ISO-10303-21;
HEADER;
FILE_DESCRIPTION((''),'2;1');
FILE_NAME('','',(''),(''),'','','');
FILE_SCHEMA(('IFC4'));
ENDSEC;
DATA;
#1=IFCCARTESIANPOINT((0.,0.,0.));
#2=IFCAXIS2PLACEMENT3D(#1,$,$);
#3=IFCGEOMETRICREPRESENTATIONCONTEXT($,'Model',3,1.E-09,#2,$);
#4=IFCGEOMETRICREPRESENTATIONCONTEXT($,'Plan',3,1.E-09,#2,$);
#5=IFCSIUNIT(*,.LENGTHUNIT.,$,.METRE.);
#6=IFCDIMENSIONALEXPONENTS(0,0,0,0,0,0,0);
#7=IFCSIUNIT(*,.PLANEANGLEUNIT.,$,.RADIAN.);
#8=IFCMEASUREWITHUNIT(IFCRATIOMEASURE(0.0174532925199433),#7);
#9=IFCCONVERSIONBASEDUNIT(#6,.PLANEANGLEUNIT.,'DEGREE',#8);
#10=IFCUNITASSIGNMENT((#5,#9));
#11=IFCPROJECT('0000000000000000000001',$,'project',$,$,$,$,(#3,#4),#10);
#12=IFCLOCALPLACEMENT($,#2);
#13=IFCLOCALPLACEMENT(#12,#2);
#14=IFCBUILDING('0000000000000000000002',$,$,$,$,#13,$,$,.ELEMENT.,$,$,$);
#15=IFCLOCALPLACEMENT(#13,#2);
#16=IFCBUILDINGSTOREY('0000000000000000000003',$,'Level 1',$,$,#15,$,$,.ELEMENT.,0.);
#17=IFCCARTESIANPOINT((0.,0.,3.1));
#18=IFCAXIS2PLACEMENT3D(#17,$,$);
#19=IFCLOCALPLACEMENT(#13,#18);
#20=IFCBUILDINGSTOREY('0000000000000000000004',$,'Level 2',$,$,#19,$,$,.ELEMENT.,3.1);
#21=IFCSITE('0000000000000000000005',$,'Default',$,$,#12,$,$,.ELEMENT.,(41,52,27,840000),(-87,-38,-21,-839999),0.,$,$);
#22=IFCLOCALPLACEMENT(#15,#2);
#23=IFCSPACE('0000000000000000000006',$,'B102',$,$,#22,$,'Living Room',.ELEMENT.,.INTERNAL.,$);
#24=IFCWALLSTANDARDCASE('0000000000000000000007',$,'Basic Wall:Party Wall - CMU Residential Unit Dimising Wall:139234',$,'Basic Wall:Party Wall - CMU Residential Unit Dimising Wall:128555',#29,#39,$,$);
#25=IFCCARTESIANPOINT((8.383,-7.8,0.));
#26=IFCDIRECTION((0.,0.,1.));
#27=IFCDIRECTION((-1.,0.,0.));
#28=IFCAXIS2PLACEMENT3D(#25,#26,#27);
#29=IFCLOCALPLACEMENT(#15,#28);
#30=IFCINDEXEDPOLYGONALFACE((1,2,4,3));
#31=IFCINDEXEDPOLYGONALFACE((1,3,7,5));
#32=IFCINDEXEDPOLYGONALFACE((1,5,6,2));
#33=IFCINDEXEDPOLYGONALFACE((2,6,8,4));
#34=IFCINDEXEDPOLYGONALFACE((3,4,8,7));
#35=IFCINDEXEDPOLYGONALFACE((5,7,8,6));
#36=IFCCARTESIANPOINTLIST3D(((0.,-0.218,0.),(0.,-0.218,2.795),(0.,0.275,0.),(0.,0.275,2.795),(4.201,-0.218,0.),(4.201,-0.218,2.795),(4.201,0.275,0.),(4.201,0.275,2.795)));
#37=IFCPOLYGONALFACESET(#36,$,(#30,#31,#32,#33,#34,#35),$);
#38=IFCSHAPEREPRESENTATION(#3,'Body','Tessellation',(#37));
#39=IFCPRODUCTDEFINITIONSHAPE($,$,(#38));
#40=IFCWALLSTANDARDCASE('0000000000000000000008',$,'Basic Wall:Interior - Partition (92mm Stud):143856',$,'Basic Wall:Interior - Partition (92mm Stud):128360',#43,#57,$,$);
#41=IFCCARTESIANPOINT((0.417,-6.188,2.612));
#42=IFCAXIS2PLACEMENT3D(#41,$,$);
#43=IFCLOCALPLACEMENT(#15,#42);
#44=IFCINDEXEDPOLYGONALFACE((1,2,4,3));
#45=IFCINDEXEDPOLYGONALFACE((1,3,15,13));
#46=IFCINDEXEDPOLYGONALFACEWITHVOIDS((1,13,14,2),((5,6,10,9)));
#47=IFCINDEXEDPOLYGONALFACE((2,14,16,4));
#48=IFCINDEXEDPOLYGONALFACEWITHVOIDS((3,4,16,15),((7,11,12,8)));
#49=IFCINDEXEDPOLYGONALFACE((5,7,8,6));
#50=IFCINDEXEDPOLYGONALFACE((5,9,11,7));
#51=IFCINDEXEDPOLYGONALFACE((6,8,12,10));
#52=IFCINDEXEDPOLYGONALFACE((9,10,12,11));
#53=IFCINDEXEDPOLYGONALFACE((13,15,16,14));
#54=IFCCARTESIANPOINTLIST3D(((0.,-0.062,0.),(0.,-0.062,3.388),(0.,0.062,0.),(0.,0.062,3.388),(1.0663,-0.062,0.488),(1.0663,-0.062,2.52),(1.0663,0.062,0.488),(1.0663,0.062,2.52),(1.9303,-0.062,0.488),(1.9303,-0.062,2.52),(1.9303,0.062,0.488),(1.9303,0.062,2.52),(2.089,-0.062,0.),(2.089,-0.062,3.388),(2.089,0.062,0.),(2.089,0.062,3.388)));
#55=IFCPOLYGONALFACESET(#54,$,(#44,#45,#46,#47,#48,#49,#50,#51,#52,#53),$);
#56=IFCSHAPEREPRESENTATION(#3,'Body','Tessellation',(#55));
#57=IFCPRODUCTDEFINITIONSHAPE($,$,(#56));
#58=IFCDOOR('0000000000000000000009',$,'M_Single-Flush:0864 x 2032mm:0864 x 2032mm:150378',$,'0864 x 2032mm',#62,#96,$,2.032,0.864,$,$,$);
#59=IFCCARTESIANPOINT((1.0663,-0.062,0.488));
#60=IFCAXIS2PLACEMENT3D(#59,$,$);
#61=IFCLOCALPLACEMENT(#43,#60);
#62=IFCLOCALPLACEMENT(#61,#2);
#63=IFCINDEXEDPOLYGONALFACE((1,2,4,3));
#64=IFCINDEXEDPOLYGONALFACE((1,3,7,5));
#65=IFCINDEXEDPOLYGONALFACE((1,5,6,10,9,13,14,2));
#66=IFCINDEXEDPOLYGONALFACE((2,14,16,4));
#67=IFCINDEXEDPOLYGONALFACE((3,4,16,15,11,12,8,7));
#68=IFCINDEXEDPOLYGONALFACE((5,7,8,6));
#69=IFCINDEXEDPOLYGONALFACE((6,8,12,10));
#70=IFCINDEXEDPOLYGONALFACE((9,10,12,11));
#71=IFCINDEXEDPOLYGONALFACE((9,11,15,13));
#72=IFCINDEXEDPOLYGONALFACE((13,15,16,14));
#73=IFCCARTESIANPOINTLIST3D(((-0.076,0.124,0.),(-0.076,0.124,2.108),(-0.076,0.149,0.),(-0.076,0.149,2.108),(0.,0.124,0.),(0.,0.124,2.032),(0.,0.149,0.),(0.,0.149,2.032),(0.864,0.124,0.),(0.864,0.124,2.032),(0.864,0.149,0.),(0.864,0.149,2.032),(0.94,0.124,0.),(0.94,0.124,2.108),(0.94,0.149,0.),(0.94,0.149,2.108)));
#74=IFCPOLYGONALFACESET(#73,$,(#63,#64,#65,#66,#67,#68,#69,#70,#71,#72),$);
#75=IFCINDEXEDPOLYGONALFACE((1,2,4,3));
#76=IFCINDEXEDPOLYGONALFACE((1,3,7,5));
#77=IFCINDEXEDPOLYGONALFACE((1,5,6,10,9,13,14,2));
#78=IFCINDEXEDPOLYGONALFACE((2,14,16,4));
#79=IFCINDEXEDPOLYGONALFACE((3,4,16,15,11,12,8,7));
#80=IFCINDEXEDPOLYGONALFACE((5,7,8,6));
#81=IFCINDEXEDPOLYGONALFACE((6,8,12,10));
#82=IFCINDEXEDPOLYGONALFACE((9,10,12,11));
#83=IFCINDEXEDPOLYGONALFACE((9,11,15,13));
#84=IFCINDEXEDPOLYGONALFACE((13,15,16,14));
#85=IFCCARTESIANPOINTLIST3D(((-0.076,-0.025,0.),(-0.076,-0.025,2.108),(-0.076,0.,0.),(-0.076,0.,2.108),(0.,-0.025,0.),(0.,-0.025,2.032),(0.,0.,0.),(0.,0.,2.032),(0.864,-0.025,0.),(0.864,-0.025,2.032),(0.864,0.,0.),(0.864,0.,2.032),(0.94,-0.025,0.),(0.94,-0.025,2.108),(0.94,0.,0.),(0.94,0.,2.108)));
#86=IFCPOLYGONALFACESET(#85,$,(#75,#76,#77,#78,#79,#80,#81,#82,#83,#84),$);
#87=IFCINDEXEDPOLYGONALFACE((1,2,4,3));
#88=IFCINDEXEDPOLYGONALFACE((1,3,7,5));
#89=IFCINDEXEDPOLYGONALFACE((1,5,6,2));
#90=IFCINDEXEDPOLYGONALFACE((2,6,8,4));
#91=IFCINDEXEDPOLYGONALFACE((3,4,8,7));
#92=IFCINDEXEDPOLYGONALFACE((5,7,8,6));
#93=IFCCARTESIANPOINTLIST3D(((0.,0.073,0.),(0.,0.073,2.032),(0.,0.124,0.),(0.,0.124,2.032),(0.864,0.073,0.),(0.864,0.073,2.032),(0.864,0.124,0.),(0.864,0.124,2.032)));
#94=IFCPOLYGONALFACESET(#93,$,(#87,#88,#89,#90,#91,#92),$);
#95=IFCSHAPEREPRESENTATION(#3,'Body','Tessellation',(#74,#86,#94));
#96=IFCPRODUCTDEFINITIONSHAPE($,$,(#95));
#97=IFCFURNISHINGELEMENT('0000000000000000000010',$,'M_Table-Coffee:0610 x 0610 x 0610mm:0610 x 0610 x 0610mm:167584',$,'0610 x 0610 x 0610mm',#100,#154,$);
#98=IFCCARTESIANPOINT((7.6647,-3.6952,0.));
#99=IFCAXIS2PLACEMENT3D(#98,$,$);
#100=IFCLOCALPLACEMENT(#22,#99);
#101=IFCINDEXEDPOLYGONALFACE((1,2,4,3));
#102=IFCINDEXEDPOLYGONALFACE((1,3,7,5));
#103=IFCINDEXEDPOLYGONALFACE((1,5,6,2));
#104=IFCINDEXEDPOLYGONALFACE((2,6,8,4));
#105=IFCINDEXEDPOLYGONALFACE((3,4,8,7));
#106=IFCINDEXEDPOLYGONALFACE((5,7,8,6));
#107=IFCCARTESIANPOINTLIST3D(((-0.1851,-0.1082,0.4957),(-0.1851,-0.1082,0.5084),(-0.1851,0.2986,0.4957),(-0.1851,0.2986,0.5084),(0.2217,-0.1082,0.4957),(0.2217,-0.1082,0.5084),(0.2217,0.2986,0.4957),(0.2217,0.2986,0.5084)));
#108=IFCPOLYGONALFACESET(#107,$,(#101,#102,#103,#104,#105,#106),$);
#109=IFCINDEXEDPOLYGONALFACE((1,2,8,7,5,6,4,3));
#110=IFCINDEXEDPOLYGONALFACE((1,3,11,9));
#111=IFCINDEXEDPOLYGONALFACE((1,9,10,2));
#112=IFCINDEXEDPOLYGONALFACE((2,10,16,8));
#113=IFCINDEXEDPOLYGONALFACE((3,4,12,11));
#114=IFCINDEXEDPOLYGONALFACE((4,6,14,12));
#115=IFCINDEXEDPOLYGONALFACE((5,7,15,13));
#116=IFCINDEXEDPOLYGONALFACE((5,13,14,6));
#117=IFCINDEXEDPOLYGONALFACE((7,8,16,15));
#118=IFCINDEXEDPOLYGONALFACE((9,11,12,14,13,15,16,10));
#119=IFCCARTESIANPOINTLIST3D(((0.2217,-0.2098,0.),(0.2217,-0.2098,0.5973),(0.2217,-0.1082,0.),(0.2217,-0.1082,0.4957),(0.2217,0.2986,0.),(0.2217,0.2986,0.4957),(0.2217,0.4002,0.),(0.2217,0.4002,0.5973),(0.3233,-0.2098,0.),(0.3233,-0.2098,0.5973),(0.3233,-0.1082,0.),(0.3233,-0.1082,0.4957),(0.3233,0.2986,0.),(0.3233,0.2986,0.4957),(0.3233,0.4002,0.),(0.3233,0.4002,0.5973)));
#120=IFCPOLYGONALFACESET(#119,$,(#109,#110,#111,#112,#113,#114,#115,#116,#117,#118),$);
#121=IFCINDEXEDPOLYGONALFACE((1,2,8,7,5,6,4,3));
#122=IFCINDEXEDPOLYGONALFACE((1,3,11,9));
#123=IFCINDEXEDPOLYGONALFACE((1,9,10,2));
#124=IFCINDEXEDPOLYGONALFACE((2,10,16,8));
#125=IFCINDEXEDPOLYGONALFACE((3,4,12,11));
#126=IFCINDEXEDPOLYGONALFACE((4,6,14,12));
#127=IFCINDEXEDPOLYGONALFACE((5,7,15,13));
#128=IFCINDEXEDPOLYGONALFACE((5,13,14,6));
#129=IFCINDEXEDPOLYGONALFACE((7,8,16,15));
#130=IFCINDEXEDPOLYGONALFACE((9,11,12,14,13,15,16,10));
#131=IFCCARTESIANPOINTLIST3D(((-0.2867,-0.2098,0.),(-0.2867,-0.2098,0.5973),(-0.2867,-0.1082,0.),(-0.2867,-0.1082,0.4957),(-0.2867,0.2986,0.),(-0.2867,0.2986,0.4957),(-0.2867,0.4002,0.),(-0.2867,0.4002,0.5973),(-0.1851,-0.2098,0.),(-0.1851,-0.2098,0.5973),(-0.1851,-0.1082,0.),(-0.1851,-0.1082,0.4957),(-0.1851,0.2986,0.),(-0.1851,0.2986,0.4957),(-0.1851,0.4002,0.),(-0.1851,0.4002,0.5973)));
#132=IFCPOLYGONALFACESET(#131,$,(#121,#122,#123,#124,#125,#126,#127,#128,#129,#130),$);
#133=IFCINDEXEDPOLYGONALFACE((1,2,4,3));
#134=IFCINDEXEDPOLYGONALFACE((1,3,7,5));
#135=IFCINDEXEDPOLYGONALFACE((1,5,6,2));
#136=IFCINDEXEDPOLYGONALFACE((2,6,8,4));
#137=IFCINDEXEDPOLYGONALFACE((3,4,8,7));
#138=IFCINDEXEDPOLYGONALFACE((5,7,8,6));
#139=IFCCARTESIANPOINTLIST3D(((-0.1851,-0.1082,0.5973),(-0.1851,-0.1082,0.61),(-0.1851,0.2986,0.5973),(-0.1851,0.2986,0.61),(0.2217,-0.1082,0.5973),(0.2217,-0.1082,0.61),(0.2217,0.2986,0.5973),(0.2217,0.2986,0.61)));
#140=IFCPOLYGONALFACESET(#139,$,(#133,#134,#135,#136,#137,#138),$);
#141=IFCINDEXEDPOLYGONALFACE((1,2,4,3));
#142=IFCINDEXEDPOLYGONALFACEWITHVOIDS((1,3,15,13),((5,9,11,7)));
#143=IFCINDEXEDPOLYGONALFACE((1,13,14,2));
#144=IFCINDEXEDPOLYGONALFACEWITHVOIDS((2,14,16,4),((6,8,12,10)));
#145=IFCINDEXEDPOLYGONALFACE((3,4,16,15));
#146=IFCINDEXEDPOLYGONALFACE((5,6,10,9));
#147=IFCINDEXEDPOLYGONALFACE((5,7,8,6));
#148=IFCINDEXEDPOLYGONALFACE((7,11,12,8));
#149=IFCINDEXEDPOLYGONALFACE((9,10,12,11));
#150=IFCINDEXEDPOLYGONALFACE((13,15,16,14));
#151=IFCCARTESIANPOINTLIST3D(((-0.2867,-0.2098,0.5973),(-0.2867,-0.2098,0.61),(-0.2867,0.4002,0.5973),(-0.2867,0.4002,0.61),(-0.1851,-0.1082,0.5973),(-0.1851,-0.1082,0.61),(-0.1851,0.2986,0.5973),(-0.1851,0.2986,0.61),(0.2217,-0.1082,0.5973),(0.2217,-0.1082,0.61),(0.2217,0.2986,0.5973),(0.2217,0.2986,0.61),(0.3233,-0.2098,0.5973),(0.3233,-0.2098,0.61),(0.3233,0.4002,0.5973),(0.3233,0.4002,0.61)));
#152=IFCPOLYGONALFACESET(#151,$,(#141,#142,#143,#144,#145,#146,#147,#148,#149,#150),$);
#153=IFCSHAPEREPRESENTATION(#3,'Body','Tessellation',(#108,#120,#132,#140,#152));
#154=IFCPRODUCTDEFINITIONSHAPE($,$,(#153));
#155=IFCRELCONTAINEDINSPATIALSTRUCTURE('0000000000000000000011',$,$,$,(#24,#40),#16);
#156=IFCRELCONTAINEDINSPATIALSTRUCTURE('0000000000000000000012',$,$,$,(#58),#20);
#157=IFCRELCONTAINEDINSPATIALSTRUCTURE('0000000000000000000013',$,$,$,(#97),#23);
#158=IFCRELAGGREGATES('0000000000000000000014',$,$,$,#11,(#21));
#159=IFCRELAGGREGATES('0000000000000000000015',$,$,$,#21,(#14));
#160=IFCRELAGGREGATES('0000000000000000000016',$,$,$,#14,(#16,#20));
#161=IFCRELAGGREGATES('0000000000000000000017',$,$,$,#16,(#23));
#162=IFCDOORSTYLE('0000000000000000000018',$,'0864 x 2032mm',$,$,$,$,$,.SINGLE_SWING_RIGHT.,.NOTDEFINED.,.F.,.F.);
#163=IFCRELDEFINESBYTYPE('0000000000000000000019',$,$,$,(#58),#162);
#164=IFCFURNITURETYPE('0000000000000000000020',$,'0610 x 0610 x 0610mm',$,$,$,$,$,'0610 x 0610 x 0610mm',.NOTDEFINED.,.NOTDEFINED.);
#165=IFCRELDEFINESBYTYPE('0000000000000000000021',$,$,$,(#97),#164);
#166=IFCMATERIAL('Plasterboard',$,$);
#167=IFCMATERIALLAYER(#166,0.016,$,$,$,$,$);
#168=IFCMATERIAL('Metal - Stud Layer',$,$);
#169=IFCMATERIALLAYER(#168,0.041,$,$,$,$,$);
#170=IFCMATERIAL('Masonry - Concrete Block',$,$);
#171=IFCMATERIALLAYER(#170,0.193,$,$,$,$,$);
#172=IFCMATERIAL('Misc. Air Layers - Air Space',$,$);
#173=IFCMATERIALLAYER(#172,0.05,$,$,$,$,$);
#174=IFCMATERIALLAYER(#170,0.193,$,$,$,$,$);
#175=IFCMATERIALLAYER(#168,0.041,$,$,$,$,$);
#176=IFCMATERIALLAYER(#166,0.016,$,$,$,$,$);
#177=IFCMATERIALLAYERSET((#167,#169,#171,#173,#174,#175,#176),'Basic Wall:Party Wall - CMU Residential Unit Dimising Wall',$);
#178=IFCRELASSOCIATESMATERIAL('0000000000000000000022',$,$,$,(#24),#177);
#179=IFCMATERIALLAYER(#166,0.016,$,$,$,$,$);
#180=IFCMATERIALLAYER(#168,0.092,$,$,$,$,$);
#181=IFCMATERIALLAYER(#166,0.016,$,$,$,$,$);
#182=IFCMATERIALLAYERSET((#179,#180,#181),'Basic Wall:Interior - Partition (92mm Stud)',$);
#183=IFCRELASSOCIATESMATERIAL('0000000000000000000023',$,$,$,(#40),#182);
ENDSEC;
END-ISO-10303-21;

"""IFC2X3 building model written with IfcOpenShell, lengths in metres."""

from ifc_helpers import new_model, entity, si_unit, converted_unit, frame, frame_2d, origin, origin_2d_with_axis, place, context, project, spatial, polyline, rectangle, outline, extrude, clip, bounded_halfspace, source, transform, mapped, material, layer, layer_set, layer_usage, type_object, type_shapes, element, fill, save


model = new_model("IFC2X3")

# Units and contexts
model_context = context("Model", 3, precision=1e-09, world=origin())
plan_context = context("Plan", 3, precision=1e-09, world=origin())
ifc_project = project(units=[si_unit("LENGTHUNIT", "METRE"), converted_unit("PLANEANGLEUNIT", "DEGREE", entity("IfcRatioMeasure", 0.0174532925199433), si_unit("PLANEANGLEUNIT", "RADIAN"), dimensions=[0, 0, 0, 0, 0, 0, 0])], contexts=[model_context, plan_context])

# Site, building, storey
site_placement = place(None, origin())
site = spatial("IfcSite", under=ifc_project, at=site_placement, Name="Default", CompositionType="ELEMENT", RefLatitude=(41, 52, 27, 840000), RefLongitude=(-87, -38, -21, -839999), RefElevation=0.0)
building_placement = place(site_placement, origin())
building = spatial("IfcBuilding", under=site, at=building_placement, CompositionType="ELEMENT")
storey_1_placement = place(building_placement, origin())
storey_1 = spatial("IfcBuildingStorey", under=building, at=storey_1_placement, Name="Level 1", CompositionType="ELEMENT", Elevation=0.0)

# Shared definitions
ifc_material_1 = material(Name="Misc. Air Layers - Air Space")
ifc_material_2 = material(Name="Masonry - Concrete Block")
ifc_material_3 = material(Name="Metal - Stud Layer")
ifc_material_4 = material(Name="Plasterboard")

# Wall
ifc_layer_1 = layer(ifc_material_4, 0.016)
ifc_layer_2 = layer(ifc_material_3, 0.041)
ifc_layer_3 = layer(ifc_material_2, 0.193)
ifc_layer_4 = layer(ifc_material_1, 0.05)
ifc_layer_5 = layer(ifc_material_2, 0.193)
ifc_layer_6 = layer(ifc_material_3, 0.041)
ifc_layer_7 = layer(ifc_material_4, 0.016)
ifc_layer_set_1 = layer_set([ifc_layer_1, ifc_layer_2, ifc_layer_3, ifc_layer_4, ifc_layer_5, ifc_layer_6, ifc_layer_7], Name="Basic Wall:Party Wall - CMU Residential Unit Dimising Wall")
ifc_layer_usage_1 = layer_usage(ifc_layer_set_1, "AXIS2", "NEGATIVE", 0.275)
wall_1_placement = place(storey_1_placement, frame((8.383, -7.8, 0.0), z_axis=(0.0, 0.0, 1.0), x_axis=(-1.0, 0.0, 0.0)))
element("IfcWallStandardCase", 1, at=wall_1_placement, inside=storey_1, material=ifc_layer_usage_1, Name="Basic Wall:Party Wall - CMU Residential Unit Dimising Wall:139234", ObjectType="Basic Wall:Party Wall - CMU Residential Unit Dimising Wall:128555", context=model_context, shape_type="Clipping", body=[
    clip(clip(extrude(rectangle(XDim=4.201, YDim=0.55, at=frame_2d((2.1005, 0.0), x_axis=(-1.0, 0.0))), origin(), (0.0, 0.0, 1.0), 2.795), bounded_halfspace(frame((0.0, -0.218, 2.795), z_axis=(0.0, 1.0, 0.0), x_axis=(-1.0, 0.0, 0.0)), True, frame((0.0, -0.218, 2.795), z_axis=(0.0, 1.0, 0.0), x_axis=(-1.0, 0.0, 0.0)), polyline([(0.0, 0.0), (-3.708, 0.0), (-4.201, 0.0), (-4.201, -2.795), (0.0, -2.795), (0.0, 0.0)]))), bounded_halfspace(frame((4.201, 0.275, 0.0), z_axis=(-1.0, 0.0, 0.0), x_axis=(0.0, -1.0, 0.0)), True, frame((4.201, 0.275, 0.0), z_axis=(-1.0, 0.0, 0.0), x_axis=(0.0, -1.0, 0.0)), polyline([(0.0, 0.0), (0.493, 0.0), (0.493, 2.795), (0.0, 2.795), (0.0, 0.0)]))),
])

# Wall, opening
ifc_layer_8 = layer(ifc_material_4, 0.016)
ifc_layer_9 = layer(ifc_material_3, 0.092)
ifc_layer_10 = layer(ifc_material_4, 0.016)
ifc_layer_set_2 = layer_set([ifc_layer_8, ifc_layer_9, ifc_layer_10], Name="Basic Wall:Interior - Partition (92mm Stud)")
ifc_layer_usage_2 = layer_usage(ifc_layer_set_2, "AXIS2", "NEGATIVE", 0.062)
wall_2_placement = place(storey_1_placement, frame((0.417, -6.188, 2.612)))
wall_2 = element("IfcWallStandardCase", 2, at=wall_2_placement, inside=storey_1, material=ifc_layer_usage_2, Name="Basic Wall:Interior - Partition (92mm Stud):143856", ObjectType="Basic Wall:Interior - Partition (92mm Stud):128360", context=model_context, shape_type="SweptSolid", body=[
    extrude(rectangle(XDim=2.089, YDim=0.124, at=frame_2d((1.0445, 0.0), x_axis=(-1.0, 0.0))), origin(), (0.0, 0.0, 1.0), 3.388),
])
opening_1_placement = place(wall_2_placement, frame((1.0663, -0.062, 0.488)))
opening_1 = element("IfcOpeningElement", 3, at=opening_1_placement, cuts=wall_2, ObjectType="Opening", context=model_context, shape_type="SweptSolid", body=[
    extrude(rectangle(XDim=0.864, YDim=2.032, at=frame_2d((1.016, 0.432), x_axis=(0.0, 1.0))), frame((0.0, 0.0, 0.0), z_axis=(0.0, 1.0, 0.0), x_axis=(0.0, 0.0, 1.0)), (0.0, 0.0, 1.0), 0.124),
])

# Shared definitions
storey_2_placement = place(building_placement, frame((0.0, 0.0, 3.1)))
storey_2 = spatial("IfcBuildingStorey", under=building, at=storey_2_placement, Name="Level 2", CompositionType="ELEMENT", Elevation=3.1)

# Door
door_style_1 = type_object("IfcDoorStyle", Name="0864 x 2032mm", ConstructionType="NOTDEFINED", OperationType="SINGLE_SWING_RIGHT", ParameterTakesPrecedence=False, Sizeable=False)
shared_shape_1 = source(origin(), model_context, "Body", "SweptSolid", [
    extrude(outline(polyline([(-0.508, -1.073), (0.508, -1.073), (0.508, 1.035), (0.432, 1.035), (0.432, -0.997), (-0.432, -0.997), (-0.432, 1.035), (-0.508, 1.035), (-0.508, -1.073)])), frame((0.432, 0.124, 1.035), z_axis=(0.0, 1.0, 0.0), x_axis=(1.0, 0.0, 0.0)), (0.0, 0.0, 1.0), 0.025),
    extrude(outline(polyline([(-1.073, -0.508), (1.035, -0.508), (1.035, -0.432), (-0.997, -0.432), (-0.997, 0.432), (1.035, 0.432), (1.035, 0.508), (-1.073, 0.508), (-1.073, -0.508)])), frame((0.432, -0.025, 1.035), z_axis=(0.0, 1.0, 0.0), x_axis=(0.0, 0.0, -1.0)), (0.0, 0.0, 1.0), 0.025),
    extrude(rectangle(XDim=0.051, YDim=0.864, at=origin_2d_with_axis()), frame((0.432, 0.0985, 0.0), z_axis=(0.0, 0.0, 1.0), x_axis=(0.0, 1.0, 0.0)), (0.0, 0.0, 1.0), 2.032),
])
type_shapes(door_style_1, [shared_shape_1])
door_1_placement = place(opening_1_placement, origin())
door_1 = element("IfcDoor", 4, at=door_1_placement, inside=storey_2, type_object=door_style_1, Name="M_Single-Flush:0864 x 2032mm:0864 x 2032mm:150378", ObjectType="0864 x 2032mm", OverallHeight=2.032, OverallWidth=0.864, context=model_context, shape_type="MappedRepresentation", body=[
    mapped(shared_shape_1, transform((0.0, 0.0, 0.0), scale=1.0)),
])
fill(opening_1, door_1)

# Shared definitions
space_1_placement = place(storey_1_placement, origin())
space_1 = spatial("IfcSpace", under=storey_1, at=space_1_placement, Name="B102", LongName="Living Room", CompositionType="ELEMENT", InteriorOrExteriorSpace="INTERNAL")

# Furnishing element
furniture_type_1 = type_object("IfcFurnitureType", Name="0610 x 0610 x 0610mm", ElementType="0610 x 0610 x 0610mm", AssemblyPlace="NOTDEFINED")
shared_shape_2 = source(origin(), model_context, "Body", "SweptSolid", [
    extrude(rectangle(XDim=0.4068, YDim=0.4068, at=origin_2d_with_axis()), frame((0.0183, 0.0952, 0.4957), z_axis=(0.0, 0.0, 1.0), x_axis=(-1.0, 0.0, 0.0)), (0.0, 0.0, 1.0), 0.0127),
    extrude(outline(polyline([(-0.2732, -0.305), (0.324, -0.305), (0.324, 0.305), (-0.2732, 0.305), (-0.2732, 0.2034), (0.2225, 0.2034), (0.2225, -0.2034), (-0.2732, -0.2034), (-0.2732, -0.305)])), frame((0.2217, 0.0952, 0.2732), z_axis=(1.0, 0.0, 0.0), x_axis=(0.0, 0.0, 1.0)), (0.0, 0.0, 1.0), 0.1016),
    extrude(outline(polyline([(-0.305, -0.3241), (0.305, -0.3241), (0.305, 0.2733), (0.2034, 0.2733), (0.2034, -0.2224), (-0.2034, -0.2224), (-0.2034, 0.2733), (-0.305, 0.2733), (-0.305, -0.3241)])), frame((-0.2867, 0.0952, 0.2733), z_axis=(1.0, 0.0, 0.0), x_axis=(0.0, -1.0, 0.0)), (0.0, 0.0, 1.0), 0.1016),
    extrude(rectangle(XDim=0.4068, YDim=0.4068, at=origin_2d_with_axis()), frame((0.0183, 0.0952, 0.5973), z_axis=(0.0, 0.0, 1.0), x_axis=(-1.0, 0.0, 0.0)), (0.0, 0.0, 1.0), 0.0127),
    extrude(outline(polyline([(-0.305, -0.305), (0.305, -0.305), (0.305, 0.305), (-0.305, 0.305), (-0.305, -0.305)]), holes=[polyline([(-0.2034, -0.2034), (-0.2034, 0.2034), (0.2034, 0.2034), (0.2034, -0.2034), (-0.2034, -0.2034)])]), frame((0.0183, 0.0952, 0.5973), z_axis=(0.0, 0.0, 1.0), x_axis=(-1.0, 0.0, 0.0)), (0.0, 0.0, 1.0), 0.0127),
])
type_shapes(furniture_type_1, [shared_shape_2])
for number, where, name in (
    (5, (7.6647, -3.6952, 0.0), "M_Table-Coffee:0610 x 0610 x 0610mm:0610 x 0610 x 0610mm:167584"),
):
    element("IfcFurnishingElement", number, at=place(space_1_placement, frame(where)), inside=space_1, type_object=furniture_type_1, Name=name, ObjectType="0610 x 0610 x 0610mm", context=model_context, shape_type="MappedRepresentation", body=[
        mapped(shared_shape_2, transform((0.0, 0.0, 0.0), scale=1.0)),
    ])

save(model, "model.ifc")
